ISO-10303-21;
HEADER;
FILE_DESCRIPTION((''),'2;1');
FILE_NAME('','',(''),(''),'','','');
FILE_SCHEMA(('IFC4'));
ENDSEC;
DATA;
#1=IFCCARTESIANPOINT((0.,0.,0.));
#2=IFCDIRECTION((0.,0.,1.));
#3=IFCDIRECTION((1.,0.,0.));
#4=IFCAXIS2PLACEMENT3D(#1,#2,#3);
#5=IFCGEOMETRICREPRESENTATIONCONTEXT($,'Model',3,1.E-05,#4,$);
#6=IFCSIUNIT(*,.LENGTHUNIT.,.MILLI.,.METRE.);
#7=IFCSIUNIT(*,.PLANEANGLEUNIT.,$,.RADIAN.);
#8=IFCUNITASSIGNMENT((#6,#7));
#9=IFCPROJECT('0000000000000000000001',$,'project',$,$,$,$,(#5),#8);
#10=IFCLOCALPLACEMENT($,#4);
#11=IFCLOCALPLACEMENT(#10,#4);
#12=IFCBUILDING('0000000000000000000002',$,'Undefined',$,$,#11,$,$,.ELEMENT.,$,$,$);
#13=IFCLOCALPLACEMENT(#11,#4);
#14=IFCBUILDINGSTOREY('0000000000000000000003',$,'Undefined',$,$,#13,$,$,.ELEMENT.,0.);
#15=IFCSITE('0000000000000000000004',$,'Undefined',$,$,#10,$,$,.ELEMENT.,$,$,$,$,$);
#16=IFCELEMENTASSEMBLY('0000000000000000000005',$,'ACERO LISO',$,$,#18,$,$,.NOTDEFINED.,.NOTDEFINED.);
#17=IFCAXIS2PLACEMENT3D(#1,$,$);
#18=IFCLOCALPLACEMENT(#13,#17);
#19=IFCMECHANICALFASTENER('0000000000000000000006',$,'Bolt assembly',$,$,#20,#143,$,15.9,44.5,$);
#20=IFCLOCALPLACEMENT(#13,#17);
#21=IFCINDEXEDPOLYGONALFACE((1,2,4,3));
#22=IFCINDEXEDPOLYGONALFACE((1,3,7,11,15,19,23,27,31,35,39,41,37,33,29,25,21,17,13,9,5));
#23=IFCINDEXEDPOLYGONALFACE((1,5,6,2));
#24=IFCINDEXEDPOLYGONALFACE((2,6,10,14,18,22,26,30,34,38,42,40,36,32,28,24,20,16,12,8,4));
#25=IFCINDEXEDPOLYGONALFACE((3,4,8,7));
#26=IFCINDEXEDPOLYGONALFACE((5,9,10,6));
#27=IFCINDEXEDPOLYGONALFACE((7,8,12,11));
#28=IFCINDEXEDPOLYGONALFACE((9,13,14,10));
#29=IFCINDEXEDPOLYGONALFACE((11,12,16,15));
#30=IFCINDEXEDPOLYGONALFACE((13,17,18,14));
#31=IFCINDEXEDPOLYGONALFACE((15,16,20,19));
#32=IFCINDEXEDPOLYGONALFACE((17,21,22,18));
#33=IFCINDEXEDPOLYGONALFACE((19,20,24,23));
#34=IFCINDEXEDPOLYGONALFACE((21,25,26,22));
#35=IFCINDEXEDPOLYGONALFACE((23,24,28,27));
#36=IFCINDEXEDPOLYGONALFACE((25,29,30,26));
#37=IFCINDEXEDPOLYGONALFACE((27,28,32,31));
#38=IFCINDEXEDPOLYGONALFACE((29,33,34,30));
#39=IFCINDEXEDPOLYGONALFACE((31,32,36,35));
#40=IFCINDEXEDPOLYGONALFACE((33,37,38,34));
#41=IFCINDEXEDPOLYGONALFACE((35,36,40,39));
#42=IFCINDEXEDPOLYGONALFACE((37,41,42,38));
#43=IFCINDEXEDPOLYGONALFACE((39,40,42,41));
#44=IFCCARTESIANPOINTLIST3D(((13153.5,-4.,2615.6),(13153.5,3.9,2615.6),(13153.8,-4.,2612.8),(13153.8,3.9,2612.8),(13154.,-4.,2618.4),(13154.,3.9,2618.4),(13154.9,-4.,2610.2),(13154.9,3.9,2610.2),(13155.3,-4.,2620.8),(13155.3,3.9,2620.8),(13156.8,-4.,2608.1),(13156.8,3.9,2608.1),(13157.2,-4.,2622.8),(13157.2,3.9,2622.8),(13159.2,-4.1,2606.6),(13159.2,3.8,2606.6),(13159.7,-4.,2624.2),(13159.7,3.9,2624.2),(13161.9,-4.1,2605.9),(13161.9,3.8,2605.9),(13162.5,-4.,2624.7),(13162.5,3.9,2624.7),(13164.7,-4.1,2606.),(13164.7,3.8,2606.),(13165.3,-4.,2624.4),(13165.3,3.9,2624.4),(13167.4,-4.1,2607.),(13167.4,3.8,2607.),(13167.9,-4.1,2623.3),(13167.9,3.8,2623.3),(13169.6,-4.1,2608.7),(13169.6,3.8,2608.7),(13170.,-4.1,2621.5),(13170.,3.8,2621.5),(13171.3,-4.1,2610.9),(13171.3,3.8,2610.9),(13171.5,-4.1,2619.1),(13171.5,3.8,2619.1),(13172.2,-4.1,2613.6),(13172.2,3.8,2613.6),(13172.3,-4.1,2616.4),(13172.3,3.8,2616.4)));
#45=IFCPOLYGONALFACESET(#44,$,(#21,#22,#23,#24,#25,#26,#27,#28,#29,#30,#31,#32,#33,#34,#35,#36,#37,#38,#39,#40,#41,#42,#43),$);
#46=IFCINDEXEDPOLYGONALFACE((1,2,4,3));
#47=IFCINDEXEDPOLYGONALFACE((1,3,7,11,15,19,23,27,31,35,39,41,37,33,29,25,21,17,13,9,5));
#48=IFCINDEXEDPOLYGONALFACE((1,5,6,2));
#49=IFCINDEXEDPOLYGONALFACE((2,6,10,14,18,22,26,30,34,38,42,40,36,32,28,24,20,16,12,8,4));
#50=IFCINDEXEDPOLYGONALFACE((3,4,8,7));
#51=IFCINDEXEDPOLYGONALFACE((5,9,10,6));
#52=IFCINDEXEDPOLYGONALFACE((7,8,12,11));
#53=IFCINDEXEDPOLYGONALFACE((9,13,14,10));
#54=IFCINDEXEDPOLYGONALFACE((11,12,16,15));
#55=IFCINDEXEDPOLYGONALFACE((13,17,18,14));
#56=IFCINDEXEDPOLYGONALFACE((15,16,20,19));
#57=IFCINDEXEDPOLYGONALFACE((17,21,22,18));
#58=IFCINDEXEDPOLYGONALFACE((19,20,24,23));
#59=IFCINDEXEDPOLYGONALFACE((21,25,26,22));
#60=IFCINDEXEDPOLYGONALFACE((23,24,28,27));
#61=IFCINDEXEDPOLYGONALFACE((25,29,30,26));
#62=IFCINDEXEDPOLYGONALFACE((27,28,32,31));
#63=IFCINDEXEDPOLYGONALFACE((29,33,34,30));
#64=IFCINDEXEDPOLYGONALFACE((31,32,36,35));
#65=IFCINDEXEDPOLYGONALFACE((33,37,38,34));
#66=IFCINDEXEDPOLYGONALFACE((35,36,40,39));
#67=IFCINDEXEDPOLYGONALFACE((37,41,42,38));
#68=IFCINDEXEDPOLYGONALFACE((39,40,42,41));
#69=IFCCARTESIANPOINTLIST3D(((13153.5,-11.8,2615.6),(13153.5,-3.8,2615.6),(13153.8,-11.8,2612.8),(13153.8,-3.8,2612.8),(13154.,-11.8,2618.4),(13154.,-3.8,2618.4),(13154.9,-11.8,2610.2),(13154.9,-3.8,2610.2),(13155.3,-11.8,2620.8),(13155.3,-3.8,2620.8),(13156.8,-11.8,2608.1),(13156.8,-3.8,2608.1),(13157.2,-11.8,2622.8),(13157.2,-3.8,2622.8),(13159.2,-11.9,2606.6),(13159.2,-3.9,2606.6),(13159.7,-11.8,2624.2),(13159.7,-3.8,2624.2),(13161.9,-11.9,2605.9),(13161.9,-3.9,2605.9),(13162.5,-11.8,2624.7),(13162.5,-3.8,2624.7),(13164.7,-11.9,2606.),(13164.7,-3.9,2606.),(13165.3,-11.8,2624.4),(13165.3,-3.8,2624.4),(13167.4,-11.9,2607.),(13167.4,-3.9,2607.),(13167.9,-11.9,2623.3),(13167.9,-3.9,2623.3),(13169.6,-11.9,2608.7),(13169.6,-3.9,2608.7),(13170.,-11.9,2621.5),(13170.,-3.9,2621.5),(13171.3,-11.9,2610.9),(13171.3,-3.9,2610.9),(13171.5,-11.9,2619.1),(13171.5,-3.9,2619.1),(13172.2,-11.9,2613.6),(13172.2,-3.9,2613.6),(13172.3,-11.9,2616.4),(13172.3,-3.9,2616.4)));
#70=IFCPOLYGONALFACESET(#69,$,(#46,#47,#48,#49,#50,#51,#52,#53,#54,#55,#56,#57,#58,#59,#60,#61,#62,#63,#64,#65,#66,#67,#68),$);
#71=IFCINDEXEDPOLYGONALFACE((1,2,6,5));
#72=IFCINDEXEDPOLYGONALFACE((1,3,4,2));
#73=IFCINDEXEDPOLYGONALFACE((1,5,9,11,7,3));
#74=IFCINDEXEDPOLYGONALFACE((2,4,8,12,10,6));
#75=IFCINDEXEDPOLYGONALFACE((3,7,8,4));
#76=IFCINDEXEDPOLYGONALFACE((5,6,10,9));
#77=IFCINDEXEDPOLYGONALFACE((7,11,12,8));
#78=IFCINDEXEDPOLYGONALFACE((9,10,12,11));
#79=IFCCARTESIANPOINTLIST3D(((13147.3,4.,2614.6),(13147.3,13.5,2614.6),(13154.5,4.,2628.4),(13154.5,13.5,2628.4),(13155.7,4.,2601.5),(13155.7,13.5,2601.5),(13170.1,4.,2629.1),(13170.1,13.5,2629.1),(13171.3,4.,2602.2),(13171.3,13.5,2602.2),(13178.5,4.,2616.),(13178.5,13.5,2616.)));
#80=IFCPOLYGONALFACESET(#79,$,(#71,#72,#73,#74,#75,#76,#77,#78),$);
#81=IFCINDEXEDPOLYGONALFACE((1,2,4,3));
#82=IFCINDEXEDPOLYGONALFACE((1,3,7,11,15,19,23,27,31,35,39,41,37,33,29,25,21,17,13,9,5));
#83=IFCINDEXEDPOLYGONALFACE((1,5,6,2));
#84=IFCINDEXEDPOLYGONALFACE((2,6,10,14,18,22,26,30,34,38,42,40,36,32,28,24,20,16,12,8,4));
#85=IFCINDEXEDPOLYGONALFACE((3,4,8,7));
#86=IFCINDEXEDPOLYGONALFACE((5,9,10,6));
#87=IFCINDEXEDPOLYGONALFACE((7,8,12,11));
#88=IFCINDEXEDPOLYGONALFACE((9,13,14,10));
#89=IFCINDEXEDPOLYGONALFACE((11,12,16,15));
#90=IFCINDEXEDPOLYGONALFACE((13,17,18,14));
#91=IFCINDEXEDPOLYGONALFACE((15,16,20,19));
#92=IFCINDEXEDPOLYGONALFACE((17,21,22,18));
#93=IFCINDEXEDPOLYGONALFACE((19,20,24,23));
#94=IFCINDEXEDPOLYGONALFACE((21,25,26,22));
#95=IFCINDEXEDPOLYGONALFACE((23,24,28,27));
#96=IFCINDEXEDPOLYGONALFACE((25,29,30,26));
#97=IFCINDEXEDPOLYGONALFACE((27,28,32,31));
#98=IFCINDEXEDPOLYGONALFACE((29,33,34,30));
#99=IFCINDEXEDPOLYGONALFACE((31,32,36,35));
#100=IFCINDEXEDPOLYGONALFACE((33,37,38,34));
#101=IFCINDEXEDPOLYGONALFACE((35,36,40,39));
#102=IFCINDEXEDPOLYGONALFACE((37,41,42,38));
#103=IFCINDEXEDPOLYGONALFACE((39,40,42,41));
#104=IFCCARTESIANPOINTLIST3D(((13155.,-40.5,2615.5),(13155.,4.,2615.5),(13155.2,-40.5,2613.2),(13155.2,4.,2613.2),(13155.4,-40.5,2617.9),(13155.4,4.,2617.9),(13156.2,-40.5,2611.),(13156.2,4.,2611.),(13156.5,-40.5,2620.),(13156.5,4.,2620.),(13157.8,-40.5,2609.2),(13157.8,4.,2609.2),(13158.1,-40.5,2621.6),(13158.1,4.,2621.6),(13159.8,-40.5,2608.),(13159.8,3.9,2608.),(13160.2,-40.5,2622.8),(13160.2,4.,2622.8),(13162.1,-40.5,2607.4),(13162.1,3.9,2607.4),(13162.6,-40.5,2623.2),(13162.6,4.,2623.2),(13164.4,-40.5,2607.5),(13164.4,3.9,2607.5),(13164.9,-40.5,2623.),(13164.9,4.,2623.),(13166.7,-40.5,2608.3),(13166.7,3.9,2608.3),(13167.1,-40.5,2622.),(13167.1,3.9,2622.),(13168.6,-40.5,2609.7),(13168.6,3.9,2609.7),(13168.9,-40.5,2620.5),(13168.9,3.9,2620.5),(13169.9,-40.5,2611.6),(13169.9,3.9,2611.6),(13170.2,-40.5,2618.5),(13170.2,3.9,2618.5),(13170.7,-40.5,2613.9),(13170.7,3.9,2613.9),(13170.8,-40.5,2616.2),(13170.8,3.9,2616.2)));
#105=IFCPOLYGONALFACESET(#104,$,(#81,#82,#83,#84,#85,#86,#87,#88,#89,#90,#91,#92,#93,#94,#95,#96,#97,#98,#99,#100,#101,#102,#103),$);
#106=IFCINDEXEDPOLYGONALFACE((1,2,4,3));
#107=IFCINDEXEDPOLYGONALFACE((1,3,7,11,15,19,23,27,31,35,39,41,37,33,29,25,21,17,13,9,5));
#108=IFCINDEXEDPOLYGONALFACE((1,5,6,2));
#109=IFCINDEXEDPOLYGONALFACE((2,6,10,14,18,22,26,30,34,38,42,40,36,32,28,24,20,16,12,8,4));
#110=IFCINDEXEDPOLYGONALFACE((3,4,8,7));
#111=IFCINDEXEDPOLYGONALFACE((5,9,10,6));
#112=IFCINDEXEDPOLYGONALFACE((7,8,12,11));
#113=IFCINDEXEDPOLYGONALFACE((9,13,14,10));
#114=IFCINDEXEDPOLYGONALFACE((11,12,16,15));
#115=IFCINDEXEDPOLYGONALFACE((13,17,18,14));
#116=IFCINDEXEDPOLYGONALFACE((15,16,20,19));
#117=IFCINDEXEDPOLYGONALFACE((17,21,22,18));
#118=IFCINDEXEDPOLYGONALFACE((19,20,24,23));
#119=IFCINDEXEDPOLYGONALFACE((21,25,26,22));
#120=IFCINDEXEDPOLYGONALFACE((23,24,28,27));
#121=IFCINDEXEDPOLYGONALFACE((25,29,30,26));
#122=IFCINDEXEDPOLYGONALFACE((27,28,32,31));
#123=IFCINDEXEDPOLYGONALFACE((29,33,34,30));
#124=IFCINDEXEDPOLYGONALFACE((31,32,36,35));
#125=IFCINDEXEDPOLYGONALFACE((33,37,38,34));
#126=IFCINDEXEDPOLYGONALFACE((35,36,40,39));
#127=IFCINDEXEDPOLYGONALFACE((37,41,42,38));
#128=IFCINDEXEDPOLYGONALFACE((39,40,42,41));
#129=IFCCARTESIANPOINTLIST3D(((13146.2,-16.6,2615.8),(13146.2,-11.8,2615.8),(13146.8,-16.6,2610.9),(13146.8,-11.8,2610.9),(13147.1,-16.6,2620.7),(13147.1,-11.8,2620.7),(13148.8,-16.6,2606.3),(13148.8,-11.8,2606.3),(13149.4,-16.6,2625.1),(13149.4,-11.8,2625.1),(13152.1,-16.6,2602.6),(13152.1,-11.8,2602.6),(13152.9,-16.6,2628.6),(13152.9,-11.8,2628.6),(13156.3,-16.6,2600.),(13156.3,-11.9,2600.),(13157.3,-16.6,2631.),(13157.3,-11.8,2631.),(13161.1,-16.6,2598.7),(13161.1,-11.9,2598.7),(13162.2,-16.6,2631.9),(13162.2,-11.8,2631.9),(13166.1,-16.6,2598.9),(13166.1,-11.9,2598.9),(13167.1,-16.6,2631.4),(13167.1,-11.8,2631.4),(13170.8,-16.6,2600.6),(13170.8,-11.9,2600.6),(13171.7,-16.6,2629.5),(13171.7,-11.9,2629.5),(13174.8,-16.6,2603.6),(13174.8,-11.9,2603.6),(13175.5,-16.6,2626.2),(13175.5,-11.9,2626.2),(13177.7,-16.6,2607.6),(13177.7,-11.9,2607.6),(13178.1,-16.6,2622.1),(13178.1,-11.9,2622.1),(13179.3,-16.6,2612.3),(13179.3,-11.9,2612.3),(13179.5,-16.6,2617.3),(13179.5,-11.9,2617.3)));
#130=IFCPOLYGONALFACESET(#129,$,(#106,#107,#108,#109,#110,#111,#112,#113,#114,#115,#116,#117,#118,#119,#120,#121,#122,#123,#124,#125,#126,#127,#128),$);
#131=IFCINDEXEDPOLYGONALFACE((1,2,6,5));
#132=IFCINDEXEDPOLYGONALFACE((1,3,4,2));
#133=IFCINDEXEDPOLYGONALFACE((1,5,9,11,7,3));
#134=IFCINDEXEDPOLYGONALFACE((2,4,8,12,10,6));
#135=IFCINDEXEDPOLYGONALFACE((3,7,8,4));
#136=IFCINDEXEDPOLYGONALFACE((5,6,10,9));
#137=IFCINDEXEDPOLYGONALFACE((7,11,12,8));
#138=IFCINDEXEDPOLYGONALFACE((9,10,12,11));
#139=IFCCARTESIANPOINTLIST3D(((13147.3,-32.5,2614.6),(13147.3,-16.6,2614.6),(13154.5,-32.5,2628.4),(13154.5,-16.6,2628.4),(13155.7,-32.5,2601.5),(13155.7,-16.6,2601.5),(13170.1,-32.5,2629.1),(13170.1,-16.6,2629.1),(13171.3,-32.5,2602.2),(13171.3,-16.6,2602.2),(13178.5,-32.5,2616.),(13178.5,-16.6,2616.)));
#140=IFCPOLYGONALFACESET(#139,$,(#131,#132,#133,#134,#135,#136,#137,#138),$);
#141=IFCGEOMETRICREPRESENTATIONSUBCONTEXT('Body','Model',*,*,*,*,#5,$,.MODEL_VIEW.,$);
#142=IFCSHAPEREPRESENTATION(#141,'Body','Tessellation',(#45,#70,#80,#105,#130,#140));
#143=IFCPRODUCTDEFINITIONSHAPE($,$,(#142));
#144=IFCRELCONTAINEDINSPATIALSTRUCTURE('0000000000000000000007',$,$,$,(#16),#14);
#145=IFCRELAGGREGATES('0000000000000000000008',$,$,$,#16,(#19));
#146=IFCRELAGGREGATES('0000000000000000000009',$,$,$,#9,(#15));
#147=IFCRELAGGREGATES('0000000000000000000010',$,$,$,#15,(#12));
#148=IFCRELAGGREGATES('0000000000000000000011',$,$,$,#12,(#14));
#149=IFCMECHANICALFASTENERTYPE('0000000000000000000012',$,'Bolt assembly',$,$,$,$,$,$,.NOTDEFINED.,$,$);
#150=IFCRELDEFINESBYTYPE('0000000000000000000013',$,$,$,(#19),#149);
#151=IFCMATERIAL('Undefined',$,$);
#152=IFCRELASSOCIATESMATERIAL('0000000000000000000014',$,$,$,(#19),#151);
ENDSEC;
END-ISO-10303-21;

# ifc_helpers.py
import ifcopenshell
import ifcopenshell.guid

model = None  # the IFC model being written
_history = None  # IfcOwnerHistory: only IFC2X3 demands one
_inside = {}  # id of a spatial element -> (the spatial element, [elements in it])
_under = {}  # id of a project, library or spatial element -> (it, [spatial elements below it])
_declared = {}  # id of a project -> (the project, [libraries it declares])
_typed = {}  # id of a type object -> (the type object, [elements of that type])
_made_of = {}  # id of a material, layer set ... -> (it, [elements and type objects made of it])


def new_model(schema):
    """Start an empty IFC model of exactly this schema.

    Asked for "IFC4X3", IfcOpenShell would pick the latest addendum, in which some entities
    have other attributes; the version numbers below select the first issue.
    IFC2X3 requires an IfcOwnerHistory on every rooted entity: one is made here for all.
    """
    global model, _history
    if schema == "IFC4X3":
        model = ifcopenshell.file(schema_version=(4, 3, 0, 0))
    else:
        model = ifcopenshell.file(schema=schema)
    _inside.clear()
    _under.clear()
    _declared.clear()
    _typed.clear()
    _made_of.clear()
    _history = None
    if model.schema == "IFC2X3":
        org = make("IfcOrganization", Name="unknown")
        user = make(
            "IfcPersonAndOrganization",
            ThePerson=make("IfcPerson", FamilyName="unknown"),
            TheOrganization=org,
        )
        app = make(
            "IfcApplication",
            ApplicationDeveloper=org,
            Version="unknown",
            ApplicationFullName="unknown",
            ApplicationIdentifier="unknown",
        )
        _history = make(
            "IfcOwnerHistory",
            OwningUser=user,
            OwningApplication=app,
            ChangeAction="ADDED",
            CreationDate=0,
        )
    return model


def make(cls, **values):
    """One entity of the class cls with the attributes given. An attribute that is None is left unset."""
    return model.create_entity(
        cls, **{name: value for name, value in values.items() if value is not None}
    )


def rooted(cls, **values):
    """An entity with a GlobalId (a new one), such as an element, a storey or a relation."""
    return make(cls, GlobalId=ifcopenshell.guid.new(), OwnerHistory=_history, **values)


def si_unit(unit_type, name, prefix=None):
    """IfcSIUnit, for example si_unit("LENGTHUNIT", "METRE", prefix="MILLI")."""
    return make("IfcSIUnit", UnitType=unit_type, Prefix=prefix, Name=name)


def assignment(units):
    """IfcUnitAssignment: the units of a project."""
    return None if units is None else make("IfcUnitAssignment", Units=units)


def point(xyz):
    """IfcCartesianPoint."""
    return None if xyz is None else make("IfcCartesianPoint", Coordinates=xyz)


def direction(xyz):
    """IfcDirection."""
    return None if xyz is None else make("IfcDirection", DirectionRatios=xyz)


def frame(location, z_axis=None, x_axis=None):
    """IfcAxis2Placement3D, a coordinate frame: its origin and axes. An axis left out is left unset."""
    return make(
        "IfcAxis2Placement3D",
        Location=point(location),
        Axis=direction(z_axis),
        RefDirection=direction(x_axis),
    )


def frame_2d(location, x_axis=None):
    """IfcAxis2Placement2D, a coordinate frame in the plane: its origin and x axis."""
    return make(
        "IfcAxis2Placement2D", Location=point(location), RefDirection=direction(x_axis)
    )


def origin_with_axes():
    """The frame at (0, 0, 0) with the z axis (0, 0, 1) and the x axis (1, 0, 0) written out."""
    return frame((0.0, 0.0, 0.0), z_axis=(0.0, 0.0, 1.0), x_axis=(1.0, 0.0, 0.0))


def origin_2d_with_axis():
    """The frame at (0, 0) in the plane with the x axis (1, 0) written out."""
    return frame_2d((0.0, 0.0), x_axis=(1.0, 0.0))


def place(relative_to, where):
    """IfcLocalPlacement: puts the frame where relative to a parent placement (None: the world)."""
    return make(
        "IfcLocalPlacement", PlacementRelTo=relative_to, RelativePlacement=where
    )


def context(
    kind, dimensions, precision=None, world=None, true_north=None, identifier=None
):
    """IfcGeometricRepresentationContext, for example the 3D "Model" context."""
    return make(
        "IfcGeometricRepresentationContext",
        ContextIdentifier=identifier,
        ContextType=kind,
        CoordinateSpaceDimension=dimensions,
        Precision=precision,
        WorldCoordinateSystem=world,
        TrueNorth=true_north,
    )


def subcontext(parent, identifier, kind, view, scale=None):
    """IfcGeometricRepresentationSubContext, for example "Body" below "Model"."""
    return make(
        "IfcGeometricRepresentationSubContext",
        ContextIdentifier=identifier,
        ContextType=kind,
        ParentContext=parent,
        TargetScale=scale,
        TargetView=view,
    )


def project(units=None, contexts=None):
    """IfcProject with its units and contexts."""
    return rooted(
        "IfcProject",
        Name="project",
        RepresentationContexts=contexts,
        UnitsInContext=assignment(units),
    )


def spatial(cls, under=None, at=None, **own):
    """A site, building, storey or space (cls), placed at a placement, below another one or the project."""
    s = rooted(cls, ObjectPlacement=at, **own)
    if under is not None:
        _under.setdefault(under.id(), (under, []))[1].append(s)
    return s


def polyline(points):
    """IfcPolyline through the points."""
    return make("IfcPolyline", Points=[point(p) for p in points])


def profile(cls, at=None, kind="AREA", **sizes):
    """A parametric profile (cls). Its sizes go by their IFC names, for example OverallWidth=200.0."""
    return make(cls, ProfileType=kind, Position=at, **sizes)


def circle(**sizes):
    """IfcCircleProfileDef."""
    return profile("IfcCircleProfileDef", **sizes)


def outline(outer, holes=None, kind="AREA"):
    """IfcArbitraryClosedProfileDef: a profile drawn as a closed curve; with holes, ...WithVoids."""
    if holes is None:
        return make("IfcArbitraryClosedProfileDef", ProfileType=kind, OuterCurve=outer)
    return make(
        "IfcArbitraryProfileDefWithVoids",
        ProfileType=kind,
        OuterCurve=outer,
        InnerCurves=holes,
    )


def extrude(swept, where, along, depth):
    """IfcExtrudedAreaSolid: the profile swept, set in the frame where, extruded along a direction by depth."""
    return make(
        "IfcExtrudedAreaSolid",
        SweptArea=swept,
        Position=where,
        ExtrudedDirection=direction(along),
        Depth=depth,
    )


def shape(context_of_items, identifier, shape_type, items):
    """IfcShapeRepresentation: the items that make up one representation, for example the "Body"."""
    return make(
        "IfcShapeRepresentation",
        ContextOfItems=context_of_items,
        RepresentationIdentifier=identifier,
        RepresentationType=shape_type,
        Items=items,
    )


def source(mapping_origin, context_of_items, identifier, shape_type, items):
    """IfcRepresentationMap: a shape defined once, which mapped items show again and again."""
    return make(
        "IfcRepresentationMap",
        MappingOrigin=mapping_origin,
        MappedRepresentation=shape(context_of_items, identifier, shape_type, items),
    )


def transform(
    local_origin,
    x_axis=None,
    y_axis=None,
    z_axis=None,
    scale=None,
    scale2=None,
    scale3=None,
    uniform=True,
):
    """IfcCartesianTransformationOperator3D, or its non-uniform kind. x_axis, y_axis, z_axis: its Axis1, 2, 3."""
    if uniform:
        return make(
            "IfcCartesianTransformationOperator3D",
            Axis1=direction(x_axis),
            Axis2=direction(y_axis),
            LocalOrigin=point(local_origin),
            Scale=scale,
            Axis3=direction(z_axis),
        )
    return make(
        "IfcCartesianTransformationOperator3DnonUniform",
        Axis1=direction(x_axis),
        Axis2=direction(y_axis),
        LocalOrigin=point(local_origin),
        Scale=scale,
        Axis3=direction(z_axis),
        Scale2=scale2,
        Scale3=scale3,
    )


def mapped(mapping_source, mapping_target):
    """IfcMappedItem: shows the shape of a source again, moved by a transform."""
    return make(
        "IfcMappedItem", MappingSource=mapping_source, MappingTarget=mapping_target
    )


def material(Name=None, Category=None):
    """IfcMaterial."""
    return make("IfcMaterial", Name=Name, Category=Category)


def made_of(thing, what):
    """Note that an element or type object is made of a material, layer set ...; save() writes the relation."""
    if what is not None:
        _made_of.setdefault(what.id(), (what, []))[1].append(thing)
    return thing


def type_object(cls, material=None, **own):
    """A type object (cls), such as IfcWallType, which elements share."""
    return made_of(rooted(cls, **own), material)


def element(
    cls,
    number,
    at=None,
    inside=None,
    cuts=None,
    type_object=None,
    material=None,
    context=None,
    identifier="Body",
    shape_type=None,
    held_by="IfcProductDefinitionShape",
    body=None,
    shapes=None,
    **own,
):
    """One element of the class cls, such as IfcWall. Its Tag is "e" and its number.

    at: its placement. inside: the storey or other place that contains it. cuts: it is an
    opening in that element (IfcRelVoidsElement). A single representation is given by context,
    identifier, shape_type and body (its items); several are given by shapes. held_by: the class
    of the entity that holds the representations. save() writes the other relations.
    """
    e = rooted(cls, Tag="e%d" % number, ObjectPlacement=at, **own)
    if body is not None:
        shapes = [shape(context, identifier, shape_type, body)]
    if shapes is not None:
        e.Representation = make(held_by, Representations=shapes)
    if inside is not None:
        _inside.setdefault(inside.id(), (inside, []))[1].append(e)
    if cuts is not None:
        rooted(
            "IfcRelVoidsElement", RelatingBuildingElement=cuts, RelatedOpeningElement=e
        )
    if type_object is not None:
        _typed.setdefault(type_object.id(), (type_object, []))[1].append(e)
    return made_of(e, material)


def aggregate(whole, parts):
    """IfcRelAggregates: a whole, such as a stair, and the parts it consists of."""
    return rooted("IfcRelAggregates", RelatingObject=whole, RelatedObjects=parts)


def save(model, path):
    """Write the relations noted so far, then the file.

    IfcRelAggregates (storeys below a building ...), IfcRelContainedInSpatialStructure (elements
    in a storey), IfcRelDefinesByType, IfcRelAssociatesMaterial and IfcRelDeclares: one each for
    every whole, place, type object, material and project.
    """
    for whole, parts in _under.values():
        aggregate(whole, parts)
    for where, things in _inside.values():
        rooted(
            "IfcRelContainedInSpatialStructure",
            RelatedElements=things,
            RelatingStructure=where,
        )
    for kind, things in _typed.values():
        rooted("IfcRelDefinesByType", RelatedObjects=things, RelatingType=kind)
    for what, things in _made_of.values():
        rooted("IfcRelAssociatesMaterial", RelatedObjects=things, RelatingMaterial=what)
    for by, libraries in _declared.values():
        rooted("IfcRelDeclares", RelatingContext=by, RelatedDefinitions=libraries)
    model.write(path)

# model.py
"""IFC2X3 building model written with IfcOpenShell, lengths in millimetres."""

from ifc_helpers import new_model, si_unit, frame, origin_with_axes, origin_2d_with_axis, place, context, subcontext, project, spatial, polyline, circle, outline, extrude, source, transform, mapped, material, type_object, element, aggregate, save


model = new_model("IFC2X3")

# Units and contexts
model_context = context("Model", 3, precision=1e-05, world=origin_with_axes())
body_context = subcontext(model_context, "Body", "Model", "MODEL_VIEW")
ifc_project = project(units=[si_unit("LENGTHUNIT", "METRE", prefix="MILLI"), si_unit("PLANEANGLEUNIT", "RADIAN")], contexts=[model_context])

# Site, building, storey
site_placement = place(None, origin_with_axes())
site = spatial("IfcSite", under=ifc_project, at=site_placement, Name="Undefined", CompositionType="ELEMENT")
building_placement = place(site_placement, origin_with_axes())
building = spatial("IfcBuilding", under=site, at=building_placement, Name="Undefined", CompositionType="ELEMENT")
storey_placement = place(building_placement, origin_with_axes())
storey = spatial("IfcBuildingStorey", under=building, at=storey_placement, Name="Undefined", CompositionType="ELEMENT", Elevation=0.0)

# Element assembly
assembly_1_placement = place(storey_placement, origin_with_axes())
assembly_1 = element("IfcElementAssembly", 1, at=assembly_1_placement, inside=storey, Name="ACERO LISO", AssemblyPlace="NOTDEFINED", PredefinedType="NOTDEFINED")

# Mechanical fastener
ifc_material_1 = material(Name="Undefined")
mechanical_fastener_type = type_object("IfcMechanicalFastenerType", Name="Bolt assembly")
shared_shape_1 = source(origin_with_axes(), body_context, "Body", "SweptSolid", [
    extrude(circle(Radius=9.4, at=origin_2d_with_axis()), frame((0.0, -11.7, 0.0), z_axis=(0.0, 1.0, 0.0), x_axis=(1.0, 0.0, 0.0)), (0.0, 0.0, 1.0), 7.9),
    extrude(circle(Radius=9.4, at=origin_2d_with_axis()), frame((0.0, -4.0, 0.0), z_axis=(0.0, 1.0, 0.0), x_axis=(1.0, 0.0, 0.0)), (0.0, 0.0, 1.0), 8.0),
    extrude(outline(polyline([(13.5, -7.8), (13.5, 7.8), (0.0, 15.6), (-13.5, 7.8), (-13.5, -7.8), (0.0, -15.6), (13.5, -7.8)])), frame((0.0, -21.4, 0.0), z_axis=(0.0, 1.0, 0.0), x_axis=(1.0, 0.0, 0.0)), (0.0, 0.0, 1.0), 9.5),
    extrude(circle(Radius=7.9, at=origin_2d_with_axis()), frame((0.0, -11.8, 0.0), z_axis=(0.0, 1.0, 0.0), x_axis=(1.0, 0.0, 0.0)), (0.0, 0.0, 1.0), 44.5),
    extrude(circle(Radius=16.7, at=origin_2d_with_axis()), frame((0.0, 4.0, 0.0), z_axis=(0.0, 1.0, 0.0), x_axis=(1.0, 0.0, 0.0)), (0.0, 0.0, 1.0), 4.8),
    extrude(outline(polyline([(13.5, -7.8), (13.5, 7.8), (0.0, 15.6), (-13.5, 7.8), (-13.5, -7.8), (0.0, -15.6), (13.5, -7.8)])), frame((0.0, 8.7, 0.0), z_axis=(0.0, 1.0, 0.0), x_axis=(1.0, 0.0, 0.0)), (0.0, 0.0, 1.0), 15.9),
])
mechanical_fastener_1_placement = place(assembly_1_placement, frame((13162.9, -7.9, 2615.3), z_axis=(-0.461353, 0.0, -0.887217), x_axis=(0.887217, 0.0, -0.461353)))
mechanical_fastener_1 = element("IfcMechanicalFastener", 2, at=mechanical_fastener_1_placement, type_object=mechanical_fastener_type, material=ifc_material_1, Name="Bolt assembly", NominalDiameter=15.9, NominalLength=44.5, context=body_context, shape_type="MappedRepresentation", body=[
    mapped(shared_shape_1, transform((0.0, 0.0, 0.0))),
])
aggregate(assembly_1, [mechanical_fastener_1])

save(model, "model.ifc")
